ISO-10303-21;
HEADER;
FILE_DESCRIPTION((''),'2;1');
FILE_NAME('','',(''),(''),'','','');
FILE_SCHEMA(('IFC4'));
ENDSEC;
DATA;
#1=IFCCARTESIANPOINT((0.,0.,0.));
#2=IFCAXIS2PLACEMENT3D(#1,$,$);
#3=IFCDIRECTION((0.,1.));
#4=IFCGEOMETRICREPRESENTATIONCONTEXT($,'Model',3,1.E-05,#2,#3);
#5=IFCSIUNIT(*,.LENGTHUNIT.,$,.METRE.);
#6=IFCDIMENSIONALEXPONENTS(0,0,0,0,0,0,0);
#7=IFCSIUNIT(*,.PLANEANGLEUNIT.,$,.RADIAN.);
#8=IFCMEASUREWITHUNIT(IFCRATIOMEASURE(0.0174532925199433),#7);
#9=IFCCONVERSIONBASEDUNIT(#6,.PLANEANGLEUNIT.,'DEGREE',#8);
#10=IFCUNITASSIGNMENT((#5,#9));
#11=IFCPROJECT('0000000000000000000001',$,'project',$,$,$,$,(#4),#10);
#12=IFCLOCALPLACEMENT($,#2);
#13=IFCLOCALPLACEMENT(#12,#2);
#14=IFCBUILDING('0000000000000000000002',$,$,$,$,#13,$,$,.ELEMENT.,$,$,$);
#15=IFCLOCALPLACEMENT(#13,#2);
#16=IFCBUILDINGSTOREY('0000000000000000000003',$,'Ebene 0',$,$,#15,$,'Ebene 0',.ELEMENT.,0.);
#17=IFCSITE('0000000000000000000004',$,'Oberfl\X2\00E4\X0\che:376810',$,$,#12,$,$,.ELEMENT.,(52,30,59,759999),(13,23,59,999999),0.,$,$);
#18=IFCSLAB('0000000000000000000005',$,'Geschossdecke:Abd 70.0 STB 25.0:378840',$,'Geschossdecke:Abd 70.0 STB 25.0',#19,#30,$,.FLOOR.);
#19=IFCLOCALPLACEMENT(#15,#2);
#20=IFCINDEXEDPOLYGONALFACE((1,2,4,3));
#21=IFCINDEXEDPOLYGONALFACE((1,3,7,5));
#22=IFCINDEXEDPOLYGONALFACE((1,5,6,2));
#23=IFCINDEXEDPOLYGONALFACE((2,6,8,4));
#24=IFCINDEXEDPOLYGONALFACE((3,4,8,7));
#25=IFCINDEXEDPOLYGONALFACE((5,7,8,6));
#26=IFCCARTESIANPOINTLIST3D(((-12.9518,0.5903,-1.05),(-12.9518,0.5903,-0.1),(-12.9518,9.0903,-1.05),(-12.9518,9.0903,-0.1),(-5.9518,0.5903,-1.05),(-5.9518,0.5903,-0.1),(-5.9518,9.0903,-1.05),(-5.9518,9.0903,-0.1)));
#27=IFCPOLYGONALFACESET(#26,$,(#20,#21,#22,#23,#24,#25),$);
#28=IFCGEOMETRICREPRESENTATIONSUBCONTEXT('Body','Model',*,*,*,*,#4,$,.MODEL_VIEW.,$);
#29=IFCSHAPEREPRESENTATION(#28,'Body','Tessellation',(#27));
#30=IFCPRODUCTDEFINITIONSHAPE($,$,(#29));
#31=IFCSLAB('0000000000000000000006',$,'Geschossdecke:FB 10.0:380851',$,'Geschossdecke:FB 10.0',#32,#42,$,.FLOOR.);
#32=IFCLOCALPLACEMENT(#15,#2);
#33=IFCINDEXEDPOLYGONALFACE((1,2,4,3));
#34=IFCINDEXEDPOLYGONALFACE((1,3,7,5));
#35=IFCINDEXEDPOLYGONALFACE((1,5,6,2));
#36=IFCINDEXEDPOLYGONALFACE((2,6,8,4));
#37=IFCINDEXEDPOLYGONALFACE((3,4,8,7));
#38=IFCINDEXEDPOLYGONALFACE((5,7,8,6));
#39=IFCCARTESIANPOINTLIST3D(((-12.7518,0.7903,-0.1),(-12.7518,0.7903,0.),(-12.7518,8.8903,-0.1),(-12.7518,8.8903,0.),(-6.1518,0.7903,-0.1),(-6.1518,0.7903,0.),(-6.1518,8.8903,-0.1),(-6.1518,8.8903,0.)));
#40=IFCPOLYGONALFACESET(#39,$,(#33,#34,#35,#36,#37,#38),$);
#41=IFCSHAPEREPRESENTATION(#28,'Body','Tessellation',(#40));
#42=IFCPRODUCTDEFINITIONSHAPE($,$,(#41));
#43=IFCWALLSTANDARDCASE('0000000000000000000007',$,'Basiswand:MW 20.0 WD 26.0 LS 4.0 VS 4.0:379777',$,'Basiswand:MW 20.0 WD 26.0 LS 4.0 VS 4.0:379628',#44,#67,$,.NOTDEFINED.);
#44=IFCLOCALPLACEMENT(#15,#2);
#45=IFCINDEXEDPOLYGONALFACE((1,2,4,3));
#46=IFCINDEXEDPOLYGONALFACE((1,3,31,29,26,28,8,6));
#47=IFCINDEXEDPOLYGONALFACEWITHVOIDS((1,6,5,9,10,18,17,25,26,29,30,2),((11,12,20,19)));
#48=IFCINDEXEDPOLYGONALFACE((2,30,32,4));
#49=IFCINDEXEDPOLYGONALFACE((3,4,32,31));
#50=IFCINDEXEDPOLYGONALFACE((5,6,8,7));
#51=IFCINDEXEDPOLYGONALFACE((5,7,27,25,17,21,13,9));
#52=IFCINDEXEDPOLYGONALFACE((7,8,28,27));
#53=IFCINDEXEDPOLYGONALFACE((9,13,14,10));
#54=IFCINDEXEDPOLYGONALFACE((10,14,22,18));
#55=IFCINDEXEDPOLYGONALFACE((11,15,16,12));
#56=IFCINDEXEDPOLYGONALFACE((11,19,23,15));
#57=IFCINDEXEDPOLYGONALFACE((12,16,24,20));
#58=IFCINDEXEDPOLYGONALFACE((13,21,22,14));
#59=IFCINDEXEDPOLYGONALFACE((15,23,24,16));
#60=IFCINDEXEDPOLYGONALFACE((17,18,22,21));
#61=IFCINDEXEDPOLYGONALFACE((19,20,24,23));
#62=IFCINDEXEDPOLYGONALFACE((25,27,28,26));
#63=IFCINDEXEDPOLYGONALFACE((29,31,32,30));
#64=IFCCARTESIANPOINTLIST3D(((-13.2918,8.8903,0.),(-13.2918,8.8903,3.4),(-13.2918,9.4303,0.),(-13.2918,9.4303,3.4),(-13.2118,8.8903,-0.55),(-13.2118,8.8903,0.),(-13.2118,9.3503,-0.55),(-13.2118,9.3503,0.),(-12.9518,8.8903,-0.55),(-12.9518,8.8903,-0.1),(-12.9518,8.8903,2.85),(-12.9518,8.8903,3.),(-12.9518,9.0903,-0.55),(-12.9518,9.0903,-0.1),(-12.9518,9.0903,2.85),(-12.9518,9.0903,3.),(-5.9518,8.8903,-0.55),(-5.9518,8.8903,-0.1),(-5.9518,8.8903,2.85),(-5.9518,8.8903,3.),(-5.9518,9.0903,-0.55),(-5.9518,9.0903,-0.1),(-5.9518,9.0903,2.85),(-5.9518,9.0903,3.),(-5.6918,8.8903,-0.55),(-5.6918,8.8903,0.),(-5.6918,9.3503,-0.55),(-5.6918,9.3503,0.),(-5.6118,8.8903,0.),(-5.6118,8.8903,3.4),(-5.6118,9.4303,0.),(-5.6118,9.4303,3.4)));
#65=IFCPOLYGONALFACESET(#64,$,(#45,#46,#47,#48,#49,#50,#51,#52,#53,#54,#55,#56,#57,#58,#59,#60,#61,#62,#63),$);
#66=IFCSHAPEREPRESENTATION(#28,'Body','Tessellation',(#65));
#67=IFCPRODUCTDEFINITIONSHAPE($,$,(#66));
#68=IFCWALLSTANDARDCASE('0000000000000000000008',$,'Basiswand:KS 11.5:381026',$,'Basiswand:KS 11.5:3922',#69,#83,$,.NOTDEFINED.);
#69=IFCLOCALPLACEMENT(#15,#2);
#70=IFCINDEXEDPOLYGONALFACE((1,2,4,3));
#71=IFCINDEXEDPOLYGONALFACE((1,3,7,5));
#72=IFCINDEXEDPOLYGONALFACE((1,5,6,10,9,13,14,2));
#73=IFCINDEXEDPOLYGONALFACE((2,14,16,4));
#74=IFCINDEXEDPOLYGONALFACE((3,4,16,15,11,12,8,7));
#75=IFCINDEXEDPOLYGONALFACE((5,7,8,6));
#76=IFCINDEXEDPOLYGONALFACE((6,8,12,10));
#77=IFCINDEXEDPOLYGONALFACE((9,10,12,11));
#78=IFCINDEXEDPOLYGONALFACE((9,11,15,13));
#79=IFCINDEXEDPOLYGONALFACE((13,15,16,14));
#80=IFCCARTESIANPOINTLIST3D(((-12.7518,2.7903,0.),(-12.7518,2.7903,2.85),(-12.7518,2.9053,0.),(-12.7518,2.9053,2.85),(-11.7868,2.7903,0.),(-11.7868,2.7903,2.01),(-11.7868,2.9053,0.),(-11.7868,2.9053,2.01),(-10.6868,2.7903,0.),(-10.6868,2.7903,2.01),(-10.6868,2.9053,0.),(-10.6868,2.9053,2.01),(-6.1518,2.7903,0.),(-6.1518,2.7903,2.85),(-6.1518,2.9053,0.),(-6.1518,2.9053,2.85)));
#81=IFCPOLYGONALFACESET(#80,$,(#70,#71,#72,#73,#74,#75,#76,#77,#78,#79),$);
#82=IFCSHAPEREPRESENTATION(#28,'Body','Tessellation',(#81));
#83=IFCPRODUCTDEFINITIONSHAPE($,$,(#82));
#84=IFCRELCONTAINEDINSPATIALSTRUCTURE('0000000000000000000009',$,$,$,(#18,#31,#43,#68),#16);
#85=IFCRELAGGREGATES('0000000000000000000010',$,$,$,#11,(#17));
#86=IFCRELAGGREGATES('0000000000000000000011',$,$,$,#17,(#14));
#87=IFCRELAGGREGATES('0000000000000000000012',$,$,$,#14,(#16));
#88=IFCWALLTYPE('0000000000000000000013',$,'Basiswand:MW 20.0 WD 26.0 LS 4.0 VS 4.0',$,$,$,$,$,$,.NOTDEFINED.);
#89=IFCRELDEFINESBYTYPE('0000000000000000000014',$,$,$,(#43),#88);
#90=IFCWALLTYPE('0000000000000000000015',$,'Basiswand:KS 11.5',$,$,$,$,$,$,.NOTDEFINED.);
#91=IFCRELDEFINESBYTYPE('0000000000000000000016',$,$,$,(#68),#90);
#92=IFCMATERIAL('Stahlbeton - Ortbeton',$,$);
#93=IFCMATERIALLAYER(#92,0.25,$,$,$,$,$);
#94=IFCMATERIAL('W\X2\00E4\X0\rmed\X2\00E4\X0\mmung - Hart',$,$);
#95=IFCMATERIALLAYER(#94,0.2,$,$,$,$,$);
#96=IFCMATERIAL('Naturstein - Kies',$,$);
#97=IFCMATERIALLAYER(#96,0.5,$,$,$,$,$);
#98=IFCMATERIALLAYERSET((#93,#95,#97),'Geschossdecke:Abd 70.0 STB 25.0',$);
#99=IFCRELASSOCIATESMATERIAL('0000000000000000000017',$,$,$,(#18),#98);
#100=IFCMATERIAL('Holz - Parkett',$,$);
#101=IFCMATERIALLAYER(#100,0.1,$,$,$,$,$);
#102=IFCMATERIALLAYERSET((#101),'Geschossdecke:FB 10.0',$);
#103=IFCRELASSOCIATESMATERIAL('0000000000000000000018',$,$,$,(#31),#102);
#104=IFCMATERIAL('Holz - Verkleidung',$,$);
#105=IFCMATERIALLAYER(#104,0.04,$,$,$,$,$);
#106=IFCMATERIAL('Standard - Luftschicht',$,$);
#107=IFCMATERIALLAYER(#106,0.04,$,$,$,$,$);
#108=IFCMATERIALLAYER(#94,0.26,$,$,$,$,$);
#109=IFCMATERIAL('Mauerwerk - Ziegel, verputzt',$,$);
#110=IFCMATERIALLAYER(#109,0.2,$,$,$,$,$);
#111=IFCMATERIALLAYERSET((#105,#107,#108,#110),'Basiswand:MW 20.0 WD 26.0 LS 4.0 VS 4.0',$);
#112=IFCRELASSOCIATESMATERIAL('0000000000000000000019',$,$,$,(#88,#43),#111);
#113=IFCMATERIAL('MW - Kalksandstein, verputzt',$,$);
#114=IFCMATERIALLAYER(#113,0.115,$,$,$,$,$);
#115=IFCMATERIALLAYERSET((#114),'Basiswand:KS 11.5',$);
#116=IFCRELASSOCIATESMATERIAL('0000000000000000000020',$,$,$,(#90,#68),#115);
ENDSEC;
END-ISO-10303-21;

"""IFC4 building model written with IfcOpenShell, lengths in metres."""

from ifc_helpers import new_model, entity, si_unit, converted_unit, direction, frame, frame_2d, origin, place, context, subcontext, project, spatial, polyline, rectangle, extrude, clip, bounded_halfspace, material, layer, layer_set, layer_usage, type_object, element, save


model = new_model("IFC4")

# Units and contexts
model_context = context("Model", 3, precision=1e-05, world=origin(), true_north=direction((0.0, 1.0)))
body_context = subcontext(model_context, "Body", "Model", "MODEL_VIEW")
ifc_project = project(units=[si_unit("LENGTHUNIT", "METRE"), converted_unit("PLANEANGLEUNIT", "DEGREE", entity("IfcRatioMeasure", 0.0174532925199433), si_unit("PLANEANGLEUNIT", "RADIAN"), dimensions=[0, 0, 0, 0, 0, 0, 0])], contexts=[model_context])

# Site, building, storey
site_placement = place(None, origin())
site = spatial("IfcSite", under=ifc_project, at=site_placement, Name="Oberfläche:376810", CompositionType="ELEMENT", RefLatitude=(52, 30, 59, 759999), RefLongitude=(13, 23, 59, 999999), RefElevation=0.0)
building_placement = place(site_placement, origin())
building = spatial("IfcBuilding", under=site, at=building_placement, CompositionType="ELEMENT")
storey_placement = place(building_placement, origin())
storey = spatial("IfcBuildingStorey", under=building, at=storey_placement, Name="Ebene 0", LongName="Ebene 0", CompositionType="ELEMENT", Elevation=0.0)

# Slabs
ifc_material_1 = material(Name="Stahlbeton - Ortbeton")
ifc_layer_1 = layer(ifc_material_1, 0.25)
ifc_material_2 = material(Name="Wärmedämmung - Hart")
ifc_layer_2 = layer(ifc_material_2, 0.2)
ifc_material_3 = material(Name="Naturstein - Kies")
ifc_layer_3 = layer(ifc_material_3, 0.5)
ifc_layer_set_1 = layer_set([ifc_layer_1, ifc_layer_2, ifc_layer_3], Name="Geschossdecke:Abd 70.0 STB 25.0")
ifc_layer_usage_1 = layer_usage(ifc_layer_set_1, "AXIS3", "POSITIVE", 0.0)
slab_1_placement = place(storey_placement, origin())
element("IfcSlab", 1, at=slab_1_placement, inside=storey, material=ifc_layer_usage_1, Name="Geschossdecke:Abd 70.0 STB 25.0:378840", ObjectType="Geschossdecke:Abd 70.0 STB 25.0", PredefinedType="FLOOR", context=body_context, shape_type="SweptSolid", body=[
    extrude(rectangle(XDim=8.5, YDim=7.0, at=frame_2d((0.0, 0.0), x_axis=(1.0, 0.0))), frame((-9.4518, 4.8403, -0.1), z_axis=(0.0, 0.0, -1.0), x_axis=(0.0, 1.0, 0.0)), (0.0, 0.0, 1.0), 0.95),
])
ifc_material_4 = material(Name="Holz - Parkett")
ifc_layer_4 = layer(ifc_material_4, 0.1)
ifc_layer_set_2 = layer_set([ifc_layer_4], Name="Geschossdecke:FB 10.0")
ifc_layer_usage_2 = layer_usage(ifc_layer_set_2, "AXIS3", "POSITIVE", 0.0)
slab_2_placement = place(storey_placement, origin())
element("IfcSlab", 2, at=slab_2_placement, inside=storey, material=ifc_layer_usage_2, Name="Geschossdecke:FB 10.0:380851", ObjectType="Geschossdecke:FB 10.0", PredefinedType="FLOOR", context=body_context, shape_type="SweptSolid", body=[
    extrude(rectangle(XDim=8.1, YDim=6.6, at=frame_2d((0.0, 0.0), x_axis=(1.0, 0.0))), frame((-9.4518, 4.8403, 0.0), z_axis=(0.0, 0.0, -1.0), x_axis=(0.0, 1.0, 0.0)), (0.0, 0.0, 1.0), 0.1),
])

# Wall, openings
ifc_material_5 = material(Name="Holz - Verkleidung")
ifc_layer_5 = layer(ifc_material_5, 0.04)
ifc_material_6 = material(Name="Standard - Luftschicht")
ifc_layer_6 = layer(ifc_material_6, 0.04)
ifc_layer_7 = layer(ifc_material_2, 0.26)
ifc_material_7 = material(Name="Mauerwerk - Ziegel, verputzt")
ifc_layer_8 = layer(ifc_material_7, 0.2)
ifc_layer_set_3 = layer_set([ifc_layer_5, ifc_layer_6, ifc_layer_7, ifc_layer_8], Name="Basiswand:MW 20.0 WD 26.0 LS 4.0 VS 4.0")
ifc_layer_usage_3 = layer_usage(ifc_layer_set_3, "AXIS2", "NEGATIVE", 0.27)
wall_type_1 = type_object("IfcWallType", Name="Basiswand:MW 20.0 WD 26.0 LS 4.0 VS 4.0", PredefinedType="NOTDEFINED", material=ifc_layer_set_3)
wall_1_placement = place(storey_placement, frame((-13.2918, 9.1603, -0.55)))
wall_1 = element("IfcWallStandardCase", 3, at=wall_1_placement, inside=storey, type_object=wall_type_1, material=ifc_layer_usage_3, Name="Basiswand:MW 20.0 WD 26.0 LS 4.0 VS 4.0:379777", ObjectType="Basiswand:MW 20.0 WD 26.0 LS 4.0 VS 4.0:379628", PredefinedType="NOTDEFINED", context=body_context, shape_type="Clipping", body=[
    clip(extrude(rectangle(XDim=7.68, YDim=0.54, at=frame_2d((3.84, 0.0), x_axis=(-1.0, 0.0))), origin(), (0.0, 0.0, 1.0), 3.95), bounded_halfspace(frame((0.0, 0.27, 0.55)), True, frame((0.0, 0.27, 0.55)), polyline([(0.0, 0.0), (0.0, -0.54), (0.08, -0.54), (0.08, -0.08), (7.6, -0.08), (7.6, -0.54), (7.68, -0.54), (7.68, 0.0), (0.0, 0.0)]))),
])
opening_1_placement = place(storey_placement, frame((-13.2918, 9.1603, -0.55)))
element("IfcOpeningElement", 4, at=opening_1_placement, cuts=wall_1, ObjectType="Opening", PredefinedType="OPENING", context=body_context, shape_type="SweptSolid", body=[
    extrude(rectangle(XDim=7.0, YDim=0.2, at=frame_2d((-0.0519, -0.05), x_axis=(1.0, 0.0))), frame((3.7881, -0.22, 3.4), z_axis=(0.0, 0.0, 1.0), x_axis=(-1.0, 0.0, 0.0)), (0.0, 0.0, 1.0), 0.15),
])
opening_2_placement = place(storey_placement, frame((-13.2918, 9.1603, -0.55)))
element("IfcOpeningElement", 5, at=opening_2_placement, cuts=wall_1, ObjectType="Opening", PredefinedType="OPENING", context=body_context, shape_type="SweptSolid", body=[
    extrude(rectangle(XDim=0.45, YDim=0.2, at=frame_2d((0.0, 0.0), x_axis=(0.0, 1.0))), frame((0.34, -0.17, 0.225), z_axis=(1.0, 0.0, 0.0), x_axis=(0.0, -1.0, 0.0)), (0.0, 0.0, 1.0), 7.0),
])

# Wall, opening
ifc_material_8 = material(Name="MW - Kalksandstein, verputzt")
ifc_layer_9 = layer(ifc_material_8, 0.115)
ifc_layer_set_4 = layer_set([ifc_layer_9], Name="Basiswand:KS 11.5")
ifc_layer_usage_4 = layer_usage(ifc_layer_set_4, "AXIS2", "NEGATIVE", 0.0575)
wall_type_2 = type_object("IfcWallType", Name="Basiswand:KS 11.5", PredefinedType="NOTDEFINED", material=ifc_layer_set_4)
wall_2_placement = place(storey_placement, frame((-12.7518, 2.8478, 0.0)))
wall_2 = element("IfcWallStandardCase", 6, at=wall_2_placement, inside=storey, type_object=wall_type_2, material=ifc_layer_usage_4, Name="Basiswand:KS 11.5:381026", ObjectType="Basiswand:KS 11.5:3922", PredefinedType="NOTDEFINED", context=body_context, shape_type="SweptSolid", body=[
    extrude(rectangle(XDim=6.6, YDim=0.115, at=frame_2d((3.3, 0.0), x_axis=(-1.0, 0.0))), origin(), (0.0, 0.0, 1.0), 2.85),
])
opening_3_placement = place(wall_2_placement, frame((0.965, -0.0575, 0.0)))
element("IfcOpeningElement", 7, at=opening_3_placement, cuts=wall_2, ObjectType="Opening", PredefinedType="OPENING", context=body_context, shape_type="SweptSolid", body=[
    extrude(rectangle(XDim=2.01, YDim=1.1, at=frame_2d((1.005, 0.55), x_axis=(1.0, 0.0))), frame((0.0, 0.0, 0.0), z_axis=(0.0, 1.0, 0.0), x_axis=(0.0, 0.0, 1.0)), (0.0, 0.0, 1.0), 0.115),
])

save(model, "model.ifc")
